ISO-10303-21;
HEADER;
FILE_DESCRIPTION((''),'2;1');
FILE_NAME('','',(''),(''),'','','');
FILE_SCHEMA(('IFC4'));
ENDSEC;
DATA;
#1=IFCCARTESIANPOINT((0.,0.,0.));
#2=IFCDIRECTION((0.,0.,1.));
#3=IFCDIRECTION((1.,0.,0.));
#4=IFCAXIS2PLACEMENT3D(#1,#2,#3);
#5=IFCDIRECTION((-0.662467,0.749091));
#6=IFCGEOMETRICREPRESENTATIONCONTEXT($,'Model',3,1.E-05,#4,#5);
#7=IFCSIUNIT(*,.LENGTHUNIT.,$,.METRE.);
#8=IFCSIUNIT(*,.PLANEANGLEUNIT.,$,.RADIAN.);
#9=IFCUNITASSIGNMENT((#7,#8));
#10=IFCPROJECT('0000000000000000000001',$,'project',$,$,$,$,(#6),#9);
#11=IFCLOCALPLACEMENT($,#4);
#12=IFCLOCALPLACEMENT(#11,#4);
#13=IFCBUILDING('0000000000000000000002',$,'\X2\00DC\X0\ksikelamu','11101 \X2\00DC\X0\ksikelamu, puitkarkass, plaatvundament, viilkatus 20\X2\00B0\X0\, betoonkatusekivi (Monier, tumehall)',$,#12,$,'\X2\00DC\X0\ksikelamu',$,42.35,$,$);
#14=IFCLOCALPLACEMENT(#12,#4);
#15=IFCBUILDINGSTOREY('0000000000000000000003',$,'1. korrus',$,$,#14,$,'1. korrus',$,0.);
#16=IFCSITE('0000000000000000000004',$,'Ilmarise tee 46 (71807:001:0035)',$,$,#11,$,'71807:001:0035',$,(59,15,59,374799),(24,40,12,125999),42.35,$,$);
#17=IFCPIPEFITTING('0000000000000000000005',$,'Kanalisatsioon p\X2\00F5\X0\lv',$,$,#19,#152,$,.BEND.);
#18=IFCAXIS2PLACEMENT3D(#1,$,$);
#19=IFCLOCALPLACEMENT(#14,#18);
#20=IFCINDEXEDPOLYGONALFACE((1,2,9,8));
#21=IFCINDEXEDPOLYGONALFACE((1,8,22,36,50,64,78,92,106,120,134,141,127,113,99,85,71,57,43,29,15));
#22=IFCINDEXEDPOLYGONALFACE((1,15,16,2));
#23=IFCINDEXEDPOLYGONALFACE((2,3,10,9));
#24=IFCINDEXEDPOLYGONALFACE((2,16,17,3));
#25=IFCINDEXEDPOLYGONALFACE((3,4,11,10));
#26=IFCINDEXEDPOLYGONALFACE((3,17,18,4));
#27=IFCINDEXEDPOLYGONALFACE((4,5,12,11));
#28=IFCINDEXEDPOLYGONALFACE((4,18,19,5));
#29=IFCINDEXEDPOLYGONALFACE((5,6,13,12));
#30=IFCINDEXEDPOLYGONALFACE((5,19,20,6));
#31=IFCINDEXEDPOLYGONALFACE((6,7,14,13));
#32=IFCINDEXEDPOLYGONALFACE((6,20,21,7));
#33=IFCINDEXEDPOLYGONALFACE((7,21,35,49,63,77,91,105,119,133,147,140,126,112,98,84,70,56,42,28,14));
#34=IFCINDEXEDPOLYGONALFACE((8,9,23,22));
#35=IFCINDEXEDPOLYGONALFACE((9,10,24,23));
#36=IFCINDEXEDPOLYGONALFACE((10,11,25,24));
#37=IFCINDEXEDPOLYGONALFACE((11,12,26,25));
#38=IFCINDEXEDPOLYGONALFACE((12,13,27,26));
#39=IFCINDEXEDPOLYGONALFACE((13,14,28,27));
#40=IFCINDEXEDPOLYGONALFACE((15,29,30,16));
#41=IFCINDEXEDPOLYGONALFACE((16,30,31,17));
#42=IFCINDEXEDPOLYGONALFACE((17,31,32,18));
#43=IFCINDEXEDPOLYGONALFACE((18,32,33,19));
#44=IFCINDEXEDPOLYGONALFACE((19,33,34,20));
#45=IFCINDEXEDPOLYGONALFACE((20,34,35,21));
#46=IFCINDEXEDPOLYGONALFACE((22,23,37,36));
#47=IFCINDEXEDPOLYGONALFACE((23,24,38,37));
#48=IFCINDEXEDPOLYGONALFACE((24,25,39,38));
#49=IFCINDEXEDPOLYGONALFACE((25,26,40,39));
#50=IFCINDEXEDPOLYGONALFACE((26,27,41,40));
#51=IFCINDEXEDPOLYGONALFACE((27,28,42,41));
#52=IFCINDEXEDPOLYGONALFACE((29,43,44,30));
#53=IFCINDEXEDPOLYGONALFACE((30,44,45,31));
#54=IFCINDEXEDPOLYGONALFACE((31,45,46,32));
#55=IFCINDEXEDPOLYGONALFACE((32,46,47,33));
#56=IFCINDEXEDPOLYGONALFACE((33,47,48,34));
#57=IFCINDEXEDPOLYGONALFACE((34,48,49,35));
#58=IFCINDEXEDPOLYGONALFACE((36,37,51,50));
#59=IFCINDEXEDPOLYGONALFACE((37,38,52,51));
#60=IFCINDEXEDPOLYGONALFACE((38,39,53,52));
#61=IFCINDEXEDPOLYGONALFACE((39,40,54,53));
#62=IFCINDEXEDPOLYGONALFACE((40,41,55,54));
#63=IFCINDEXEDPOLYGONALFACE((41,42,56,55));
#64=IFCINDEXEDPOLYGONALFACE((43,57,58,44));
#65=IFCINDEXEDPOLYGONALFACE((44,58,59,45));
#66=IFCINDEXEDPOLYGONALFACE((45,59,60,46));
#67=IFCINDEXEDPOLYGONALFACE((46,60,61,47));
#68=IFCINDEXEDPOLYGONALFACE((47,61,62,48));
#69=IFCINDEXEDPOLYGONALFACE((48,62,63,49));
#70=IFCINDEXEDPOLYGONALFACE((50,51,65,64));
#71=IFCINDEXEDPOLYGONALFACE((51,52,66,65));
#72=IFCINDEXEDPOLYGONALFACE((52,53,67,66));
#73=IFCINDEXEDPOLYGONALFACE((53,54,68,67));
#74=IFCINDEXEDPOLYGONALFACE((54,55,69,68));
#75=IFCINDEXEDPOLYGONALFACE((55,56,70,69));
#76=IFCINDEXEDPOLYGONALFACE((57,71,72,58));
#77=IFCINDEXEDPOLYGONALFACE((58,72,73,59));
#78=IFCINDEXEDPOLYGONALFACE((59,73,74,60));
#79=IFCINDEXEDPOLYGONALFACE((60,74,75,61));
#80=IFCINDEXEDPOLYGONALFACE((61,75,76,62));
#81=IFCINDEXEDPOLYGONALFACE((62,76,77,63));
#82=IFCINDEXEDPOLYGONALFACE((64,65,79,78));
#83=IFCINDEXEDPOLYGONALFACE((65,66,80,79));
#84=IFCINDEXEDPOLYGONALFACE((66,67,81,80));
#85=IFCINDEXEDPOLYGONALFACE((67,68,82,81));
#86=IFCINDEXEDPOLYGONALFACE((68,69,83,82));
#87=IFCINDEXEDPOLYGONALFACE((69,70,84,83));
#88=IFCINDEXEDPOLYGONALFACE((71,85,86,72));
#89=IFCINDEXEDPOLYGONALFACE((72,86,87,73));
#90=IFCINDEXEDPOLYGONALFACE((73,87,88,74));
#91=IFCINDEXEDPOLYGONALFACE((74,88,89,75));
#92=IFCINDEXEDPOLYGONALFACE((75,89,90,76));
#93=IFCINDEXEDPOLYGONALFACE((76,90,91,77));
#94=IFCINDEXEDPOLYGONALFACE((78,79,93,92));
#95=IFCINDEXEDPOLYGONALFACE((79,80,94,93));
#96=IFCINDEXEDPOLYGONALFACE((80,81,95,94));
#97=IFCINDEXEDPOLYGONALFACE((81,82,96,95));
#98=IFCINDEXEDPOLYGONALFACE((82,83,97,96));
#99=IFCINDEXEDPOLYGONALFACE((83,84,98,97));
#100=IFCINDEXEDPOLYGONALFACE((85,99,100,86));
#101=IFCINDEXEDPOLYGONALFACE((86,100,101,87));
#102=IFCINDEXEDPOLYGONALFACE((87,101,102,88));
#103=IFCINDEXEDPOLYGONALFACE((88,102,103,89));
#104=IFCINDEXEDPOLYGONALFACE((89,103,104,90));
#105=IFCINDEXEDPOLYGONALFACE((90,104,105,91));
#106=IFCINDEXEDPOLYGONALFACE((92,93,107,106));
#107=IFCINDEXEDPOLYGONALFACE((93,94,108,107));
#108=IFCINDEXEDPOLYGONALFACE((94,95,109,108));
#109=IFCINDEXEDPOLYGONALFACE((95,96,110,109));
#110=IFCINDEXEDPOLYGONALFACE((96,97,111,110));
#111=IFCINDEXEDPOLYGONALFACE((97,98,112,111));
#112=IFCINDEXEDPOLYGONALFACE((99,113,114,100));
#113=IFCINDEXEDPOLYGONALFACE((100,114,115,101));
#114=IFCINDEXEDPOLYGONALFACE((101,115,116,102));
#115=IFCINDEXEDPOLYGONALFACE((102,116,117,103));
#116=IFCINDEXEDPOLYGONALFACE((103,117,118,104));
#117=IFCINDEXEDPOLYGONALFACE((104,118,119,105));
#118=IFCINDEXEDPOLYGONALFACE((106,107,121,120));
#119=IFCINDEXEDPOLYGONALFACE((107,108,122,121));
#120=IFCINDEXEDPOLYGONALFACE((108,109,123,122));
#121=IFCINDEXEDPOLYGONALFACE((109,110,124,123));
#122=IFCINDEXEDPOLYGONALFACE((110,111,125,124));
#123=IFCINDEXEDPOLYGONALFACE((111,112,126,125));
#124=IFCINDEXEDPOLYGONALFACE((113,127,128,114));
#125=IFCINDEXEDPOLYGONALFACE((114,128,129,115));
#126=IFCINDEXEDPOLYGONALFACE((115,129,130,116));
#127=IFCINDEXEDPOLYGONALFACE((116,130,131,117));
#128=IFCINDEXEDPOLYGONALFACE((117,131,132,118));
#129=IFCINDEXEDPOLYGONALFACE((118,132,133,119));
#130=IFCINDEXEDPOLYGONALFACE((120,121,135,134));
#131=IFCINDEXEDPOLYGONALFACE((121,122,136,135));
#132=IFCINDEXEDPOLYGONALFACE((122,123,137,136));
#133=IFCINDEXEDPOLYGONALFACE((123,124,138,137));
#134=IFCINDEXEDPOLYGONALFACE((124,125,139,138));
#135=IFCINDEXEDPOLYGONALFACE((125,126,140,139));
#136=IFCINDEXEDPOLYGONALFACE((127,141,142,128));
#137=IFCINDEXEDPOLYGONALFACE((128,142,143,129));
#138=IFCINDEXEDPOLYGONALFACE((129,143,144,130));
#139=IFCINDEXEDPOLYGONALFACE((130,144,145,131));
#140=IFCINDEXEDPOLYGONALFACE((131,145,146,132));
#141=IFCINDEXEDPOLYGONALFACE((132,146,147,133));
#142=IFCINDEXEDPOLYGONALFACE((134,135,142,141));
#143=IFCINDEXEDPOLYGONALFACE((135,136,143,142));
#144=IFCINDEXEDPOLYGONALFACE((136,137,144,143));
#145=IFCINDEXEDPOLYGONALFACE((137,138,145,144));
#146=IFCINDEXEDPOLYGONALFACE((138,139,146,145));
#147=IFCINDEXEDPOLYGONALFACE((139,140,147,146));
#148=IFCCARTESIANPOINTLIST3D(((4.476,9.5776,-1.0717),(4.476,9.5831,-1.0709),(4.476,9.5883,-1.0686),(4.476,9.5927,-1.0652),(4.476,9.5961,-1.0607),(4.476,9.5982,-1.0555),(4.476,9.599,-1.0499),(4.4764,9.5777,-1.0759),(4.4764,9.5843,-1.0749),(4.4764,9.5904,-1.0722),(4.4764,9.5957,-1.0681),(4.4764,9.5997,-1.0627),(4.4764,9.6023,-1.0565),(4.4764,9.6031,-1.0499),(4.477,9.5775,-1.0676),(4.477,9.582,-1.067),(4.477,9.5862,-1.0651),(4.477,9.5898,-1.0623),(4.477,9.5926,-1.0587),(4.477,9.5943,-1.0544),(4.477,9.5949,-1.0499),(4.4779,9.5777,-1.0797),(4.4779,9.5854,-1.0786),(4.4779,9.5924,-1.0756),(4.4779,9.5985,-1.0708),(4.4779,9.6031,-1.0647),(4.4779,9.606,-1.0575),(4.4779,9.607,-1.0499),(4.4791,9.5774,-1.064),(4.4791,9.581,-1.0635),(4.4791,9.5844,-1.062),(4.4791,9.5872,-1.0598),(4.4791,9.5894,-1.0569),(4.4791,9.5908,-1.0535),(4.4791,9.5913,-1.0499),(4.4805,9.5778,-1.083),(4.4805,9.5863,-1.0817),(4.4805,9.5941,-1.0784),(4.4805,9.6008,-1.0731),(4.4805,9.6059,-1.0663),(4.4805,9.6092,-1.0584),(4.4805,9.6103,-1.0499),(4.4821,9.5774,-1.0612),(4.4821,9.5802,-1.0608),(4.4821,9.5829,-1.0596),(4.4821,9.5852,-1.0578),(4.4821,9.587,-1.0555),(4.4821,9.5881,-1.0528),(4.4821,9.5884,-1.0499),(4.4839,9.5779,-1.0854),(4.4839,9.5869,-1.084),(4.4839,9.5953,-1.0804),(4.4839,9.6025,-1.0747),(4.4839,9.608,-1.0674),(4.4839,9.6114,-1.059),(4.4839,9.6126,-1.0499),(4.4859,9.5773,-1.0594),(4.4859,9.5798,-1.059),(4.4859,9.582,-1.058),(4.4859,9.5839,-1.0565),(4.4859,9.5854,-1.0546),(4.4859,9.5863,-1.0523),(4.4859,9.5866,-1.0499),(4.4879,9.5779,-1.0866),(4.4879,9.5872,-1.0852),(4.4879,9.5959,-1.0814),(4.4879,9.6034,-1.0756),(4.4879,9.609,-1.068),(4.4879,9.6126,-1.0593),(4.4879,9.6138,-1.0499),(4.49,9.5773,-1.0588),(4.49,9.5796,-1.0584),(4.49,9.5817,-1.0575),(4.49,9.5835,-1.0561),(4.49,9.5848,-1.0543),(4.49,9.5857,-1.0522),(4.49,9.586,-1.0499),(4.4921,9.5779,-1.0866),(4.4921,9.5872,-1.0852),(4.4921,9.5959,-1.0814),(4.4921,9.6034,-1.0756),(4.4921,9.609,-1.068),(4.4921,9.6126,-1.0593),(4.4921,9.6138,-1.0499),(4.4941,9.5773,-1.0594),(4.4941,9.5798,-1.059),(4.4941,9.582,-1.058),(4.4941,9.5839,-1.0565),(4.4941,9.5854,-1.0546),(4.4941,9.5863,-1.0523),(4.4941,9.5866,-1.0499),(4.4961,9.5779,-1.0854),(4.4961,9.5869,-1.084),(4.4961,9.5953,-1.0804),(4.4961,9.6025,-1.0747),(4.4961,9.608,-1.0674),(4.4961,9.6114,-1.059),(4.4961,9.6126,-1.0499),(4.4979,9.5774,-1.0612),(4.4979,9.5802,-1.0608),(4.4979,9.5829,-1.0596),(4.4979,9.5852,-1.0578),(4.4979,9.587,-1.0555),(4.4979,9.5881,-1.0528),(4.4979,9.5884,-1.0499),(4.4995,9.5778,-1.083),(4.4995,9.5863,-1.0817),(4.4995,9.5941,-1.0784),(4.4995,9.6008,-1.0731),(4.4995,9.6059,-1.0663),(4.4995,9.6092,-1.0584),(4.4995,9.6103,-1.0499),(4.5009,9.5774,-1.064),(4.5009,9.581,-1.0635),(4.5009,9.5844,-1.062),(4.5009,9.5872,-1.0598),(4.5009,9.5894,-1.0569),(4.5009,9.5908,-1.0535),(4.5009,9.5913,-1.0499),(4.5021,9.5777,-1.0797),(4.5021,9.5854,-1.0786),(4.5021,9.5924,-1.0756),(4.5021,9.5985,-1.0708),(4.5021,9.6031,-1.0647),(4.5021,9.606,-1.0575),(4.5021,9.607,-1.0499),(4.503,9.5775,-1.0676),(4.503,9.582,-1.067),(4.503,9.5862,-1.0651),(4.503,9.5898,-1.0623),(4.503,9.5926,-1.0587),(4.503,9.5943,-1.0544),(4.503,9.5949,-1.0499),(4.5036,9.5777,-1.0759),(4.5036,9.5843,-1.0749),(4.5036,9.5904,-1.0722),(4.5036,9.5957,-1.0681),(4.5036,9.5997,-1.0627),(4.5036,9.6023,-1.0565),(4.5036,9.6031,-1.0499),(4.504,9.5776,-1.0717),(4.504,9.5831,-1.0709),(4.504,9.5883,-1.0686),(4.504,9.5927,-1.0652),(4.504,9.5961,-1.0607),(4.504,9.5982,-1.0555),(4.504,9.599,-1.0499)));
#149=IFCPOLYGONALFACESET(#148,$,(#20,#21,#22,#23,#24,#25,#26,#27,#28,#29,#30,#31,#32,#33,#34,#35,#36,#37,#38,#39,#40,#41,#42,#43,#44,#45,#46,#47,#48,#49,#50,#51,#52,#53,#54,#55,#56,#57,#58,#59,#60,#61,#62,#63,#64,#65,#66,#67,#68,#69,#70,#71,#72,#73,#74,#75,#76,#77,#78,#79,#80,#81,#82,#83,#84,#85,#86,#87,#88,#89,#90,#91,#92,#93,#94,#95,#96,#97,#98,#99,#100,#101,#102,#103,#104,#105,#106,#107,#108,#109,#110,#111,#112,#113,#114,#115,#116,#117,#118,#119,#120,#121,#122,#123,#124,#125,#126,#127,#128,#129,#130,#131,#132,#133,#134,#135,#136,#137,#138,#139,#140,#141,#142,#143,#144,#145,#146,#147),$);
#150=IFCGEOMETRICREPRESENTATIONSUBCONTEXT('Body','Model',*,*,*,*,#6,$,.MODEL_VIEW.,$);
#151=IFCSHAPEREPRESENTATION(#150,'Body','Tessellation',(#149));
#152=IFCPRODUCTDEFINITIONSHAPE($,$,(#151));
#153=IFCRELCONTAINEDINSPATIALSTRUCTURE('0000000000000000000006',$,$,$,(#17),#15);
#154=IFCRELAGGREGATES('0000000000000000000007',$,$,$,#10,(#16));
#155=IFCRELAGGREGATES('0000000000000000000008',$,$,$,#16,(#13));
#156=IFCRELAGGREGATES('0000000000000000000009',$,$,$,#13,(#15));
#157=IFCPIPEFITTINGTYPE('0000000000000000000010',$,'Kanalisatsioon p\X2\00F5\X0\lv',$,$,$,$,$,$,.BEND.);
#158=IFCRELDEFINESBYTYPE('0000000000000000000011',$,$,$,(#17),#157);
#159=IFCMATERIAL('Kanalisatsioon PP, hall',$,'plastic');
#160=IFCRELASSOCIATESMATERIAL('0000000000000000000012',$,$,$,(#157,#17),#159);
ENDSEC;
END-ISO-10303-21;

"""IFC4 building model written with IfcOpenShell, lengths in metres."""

from ifc_helpers import new_model, entity, si_unit, direction, frame, origin_with_axes, place, context, subcontext, project, spatial, material, type_object, element, save


model = new_model("IFC4")

# Units and contexts
model_context = context("Model", 3, precision=1e-05, world=origin_with_axes(), true_north=direction((-0.662467, 0.749091)))
body_context = subcontext(model_context, "Body", "Model", "MODEL_VIEW")
ifc_project = project(units=[si_unit("LENGTHUNIT", "METRE"), si_unit("PLANEANGLEUNIT", "RADIAN")], contexts=[model_context])

# Site, building, storey
site_placement = place(None, origin_with_axes())
site = spatial("IfcSite", under=ifc_project, at=site_placement, Name="Ilmarise tee 46 (71807:001:0035)", LongName="71807:001:0035", RefLatitude=(59, 15, 59, 374799), RefLongitude=(24, 40, 12, 125999), RefElevation=42.35)
building_placement = place(site_placement, origin_with_axes())
building = spatial("IfcBuilding", under=site, at=building_placement, Name="Üksikelamu", Description="11101 Üksikelamu, puitkarkass, plaatvundament, viilkatus 20°, betoonkatusekivi (Monier, tumehall)", LongName="Üksikelamu", ElevationOfRefHeight=42.35)
storey_placement = place(building_placement, origin_with_axes())
storey = spatial("IfcBuildingStorey", under=building, at=storey_placement, Name="1. korrus", LongName="1. korrus", Elevation=0.0)

# Pipe fitting
ifc_material_1 = material(Name="Kanalisatsioon PP, hall", Category="plastic")
pipe_fitting_type_1 = type_object("IfcPipeFittingType", Name="Kanalisatsioon põlv", PredefinedType="BEND", material=ifc_material_1)
pipe_fitting_1_placement = place(storey_placement, frame((4.49, 9.6, -1.0723), z_axis=(0.0, 0.0, 1.0), x_axis=(1.0, 0.0, 0.0)))
element("IfcPipeFitting", 1, at=pipe_fitting_1_placement, inside=storey, type_object=pipe_fitting_type_1, material=ifc_material_1, Name="Kanalisatsioon põlv", PredefinedType="BEND", context=body_context, shape_type="SweptSolid", body=[
    entity("IfcRevolvedAreaSolid", entity("IfcCircleProfileDef", "AREA", None, None, 0.014), entity("IfcAxis2Placement3D", entity("IfcCartesianPoint", [0.0, 0.0, 0.0224]), entity("IfcDirection", [0.0, 0.0, -1.0]), entity("IfcDirection", [0.0, -1.0, 0.0])), entity("IfcAxis1Placement", entity("IfcCartesianPoint", [0.0229, 0.0, 0.0]), entity("IfcDirection", [0.0, 1.0, 0.0])), 1.550799),
])

save(model, "model.ifc")
